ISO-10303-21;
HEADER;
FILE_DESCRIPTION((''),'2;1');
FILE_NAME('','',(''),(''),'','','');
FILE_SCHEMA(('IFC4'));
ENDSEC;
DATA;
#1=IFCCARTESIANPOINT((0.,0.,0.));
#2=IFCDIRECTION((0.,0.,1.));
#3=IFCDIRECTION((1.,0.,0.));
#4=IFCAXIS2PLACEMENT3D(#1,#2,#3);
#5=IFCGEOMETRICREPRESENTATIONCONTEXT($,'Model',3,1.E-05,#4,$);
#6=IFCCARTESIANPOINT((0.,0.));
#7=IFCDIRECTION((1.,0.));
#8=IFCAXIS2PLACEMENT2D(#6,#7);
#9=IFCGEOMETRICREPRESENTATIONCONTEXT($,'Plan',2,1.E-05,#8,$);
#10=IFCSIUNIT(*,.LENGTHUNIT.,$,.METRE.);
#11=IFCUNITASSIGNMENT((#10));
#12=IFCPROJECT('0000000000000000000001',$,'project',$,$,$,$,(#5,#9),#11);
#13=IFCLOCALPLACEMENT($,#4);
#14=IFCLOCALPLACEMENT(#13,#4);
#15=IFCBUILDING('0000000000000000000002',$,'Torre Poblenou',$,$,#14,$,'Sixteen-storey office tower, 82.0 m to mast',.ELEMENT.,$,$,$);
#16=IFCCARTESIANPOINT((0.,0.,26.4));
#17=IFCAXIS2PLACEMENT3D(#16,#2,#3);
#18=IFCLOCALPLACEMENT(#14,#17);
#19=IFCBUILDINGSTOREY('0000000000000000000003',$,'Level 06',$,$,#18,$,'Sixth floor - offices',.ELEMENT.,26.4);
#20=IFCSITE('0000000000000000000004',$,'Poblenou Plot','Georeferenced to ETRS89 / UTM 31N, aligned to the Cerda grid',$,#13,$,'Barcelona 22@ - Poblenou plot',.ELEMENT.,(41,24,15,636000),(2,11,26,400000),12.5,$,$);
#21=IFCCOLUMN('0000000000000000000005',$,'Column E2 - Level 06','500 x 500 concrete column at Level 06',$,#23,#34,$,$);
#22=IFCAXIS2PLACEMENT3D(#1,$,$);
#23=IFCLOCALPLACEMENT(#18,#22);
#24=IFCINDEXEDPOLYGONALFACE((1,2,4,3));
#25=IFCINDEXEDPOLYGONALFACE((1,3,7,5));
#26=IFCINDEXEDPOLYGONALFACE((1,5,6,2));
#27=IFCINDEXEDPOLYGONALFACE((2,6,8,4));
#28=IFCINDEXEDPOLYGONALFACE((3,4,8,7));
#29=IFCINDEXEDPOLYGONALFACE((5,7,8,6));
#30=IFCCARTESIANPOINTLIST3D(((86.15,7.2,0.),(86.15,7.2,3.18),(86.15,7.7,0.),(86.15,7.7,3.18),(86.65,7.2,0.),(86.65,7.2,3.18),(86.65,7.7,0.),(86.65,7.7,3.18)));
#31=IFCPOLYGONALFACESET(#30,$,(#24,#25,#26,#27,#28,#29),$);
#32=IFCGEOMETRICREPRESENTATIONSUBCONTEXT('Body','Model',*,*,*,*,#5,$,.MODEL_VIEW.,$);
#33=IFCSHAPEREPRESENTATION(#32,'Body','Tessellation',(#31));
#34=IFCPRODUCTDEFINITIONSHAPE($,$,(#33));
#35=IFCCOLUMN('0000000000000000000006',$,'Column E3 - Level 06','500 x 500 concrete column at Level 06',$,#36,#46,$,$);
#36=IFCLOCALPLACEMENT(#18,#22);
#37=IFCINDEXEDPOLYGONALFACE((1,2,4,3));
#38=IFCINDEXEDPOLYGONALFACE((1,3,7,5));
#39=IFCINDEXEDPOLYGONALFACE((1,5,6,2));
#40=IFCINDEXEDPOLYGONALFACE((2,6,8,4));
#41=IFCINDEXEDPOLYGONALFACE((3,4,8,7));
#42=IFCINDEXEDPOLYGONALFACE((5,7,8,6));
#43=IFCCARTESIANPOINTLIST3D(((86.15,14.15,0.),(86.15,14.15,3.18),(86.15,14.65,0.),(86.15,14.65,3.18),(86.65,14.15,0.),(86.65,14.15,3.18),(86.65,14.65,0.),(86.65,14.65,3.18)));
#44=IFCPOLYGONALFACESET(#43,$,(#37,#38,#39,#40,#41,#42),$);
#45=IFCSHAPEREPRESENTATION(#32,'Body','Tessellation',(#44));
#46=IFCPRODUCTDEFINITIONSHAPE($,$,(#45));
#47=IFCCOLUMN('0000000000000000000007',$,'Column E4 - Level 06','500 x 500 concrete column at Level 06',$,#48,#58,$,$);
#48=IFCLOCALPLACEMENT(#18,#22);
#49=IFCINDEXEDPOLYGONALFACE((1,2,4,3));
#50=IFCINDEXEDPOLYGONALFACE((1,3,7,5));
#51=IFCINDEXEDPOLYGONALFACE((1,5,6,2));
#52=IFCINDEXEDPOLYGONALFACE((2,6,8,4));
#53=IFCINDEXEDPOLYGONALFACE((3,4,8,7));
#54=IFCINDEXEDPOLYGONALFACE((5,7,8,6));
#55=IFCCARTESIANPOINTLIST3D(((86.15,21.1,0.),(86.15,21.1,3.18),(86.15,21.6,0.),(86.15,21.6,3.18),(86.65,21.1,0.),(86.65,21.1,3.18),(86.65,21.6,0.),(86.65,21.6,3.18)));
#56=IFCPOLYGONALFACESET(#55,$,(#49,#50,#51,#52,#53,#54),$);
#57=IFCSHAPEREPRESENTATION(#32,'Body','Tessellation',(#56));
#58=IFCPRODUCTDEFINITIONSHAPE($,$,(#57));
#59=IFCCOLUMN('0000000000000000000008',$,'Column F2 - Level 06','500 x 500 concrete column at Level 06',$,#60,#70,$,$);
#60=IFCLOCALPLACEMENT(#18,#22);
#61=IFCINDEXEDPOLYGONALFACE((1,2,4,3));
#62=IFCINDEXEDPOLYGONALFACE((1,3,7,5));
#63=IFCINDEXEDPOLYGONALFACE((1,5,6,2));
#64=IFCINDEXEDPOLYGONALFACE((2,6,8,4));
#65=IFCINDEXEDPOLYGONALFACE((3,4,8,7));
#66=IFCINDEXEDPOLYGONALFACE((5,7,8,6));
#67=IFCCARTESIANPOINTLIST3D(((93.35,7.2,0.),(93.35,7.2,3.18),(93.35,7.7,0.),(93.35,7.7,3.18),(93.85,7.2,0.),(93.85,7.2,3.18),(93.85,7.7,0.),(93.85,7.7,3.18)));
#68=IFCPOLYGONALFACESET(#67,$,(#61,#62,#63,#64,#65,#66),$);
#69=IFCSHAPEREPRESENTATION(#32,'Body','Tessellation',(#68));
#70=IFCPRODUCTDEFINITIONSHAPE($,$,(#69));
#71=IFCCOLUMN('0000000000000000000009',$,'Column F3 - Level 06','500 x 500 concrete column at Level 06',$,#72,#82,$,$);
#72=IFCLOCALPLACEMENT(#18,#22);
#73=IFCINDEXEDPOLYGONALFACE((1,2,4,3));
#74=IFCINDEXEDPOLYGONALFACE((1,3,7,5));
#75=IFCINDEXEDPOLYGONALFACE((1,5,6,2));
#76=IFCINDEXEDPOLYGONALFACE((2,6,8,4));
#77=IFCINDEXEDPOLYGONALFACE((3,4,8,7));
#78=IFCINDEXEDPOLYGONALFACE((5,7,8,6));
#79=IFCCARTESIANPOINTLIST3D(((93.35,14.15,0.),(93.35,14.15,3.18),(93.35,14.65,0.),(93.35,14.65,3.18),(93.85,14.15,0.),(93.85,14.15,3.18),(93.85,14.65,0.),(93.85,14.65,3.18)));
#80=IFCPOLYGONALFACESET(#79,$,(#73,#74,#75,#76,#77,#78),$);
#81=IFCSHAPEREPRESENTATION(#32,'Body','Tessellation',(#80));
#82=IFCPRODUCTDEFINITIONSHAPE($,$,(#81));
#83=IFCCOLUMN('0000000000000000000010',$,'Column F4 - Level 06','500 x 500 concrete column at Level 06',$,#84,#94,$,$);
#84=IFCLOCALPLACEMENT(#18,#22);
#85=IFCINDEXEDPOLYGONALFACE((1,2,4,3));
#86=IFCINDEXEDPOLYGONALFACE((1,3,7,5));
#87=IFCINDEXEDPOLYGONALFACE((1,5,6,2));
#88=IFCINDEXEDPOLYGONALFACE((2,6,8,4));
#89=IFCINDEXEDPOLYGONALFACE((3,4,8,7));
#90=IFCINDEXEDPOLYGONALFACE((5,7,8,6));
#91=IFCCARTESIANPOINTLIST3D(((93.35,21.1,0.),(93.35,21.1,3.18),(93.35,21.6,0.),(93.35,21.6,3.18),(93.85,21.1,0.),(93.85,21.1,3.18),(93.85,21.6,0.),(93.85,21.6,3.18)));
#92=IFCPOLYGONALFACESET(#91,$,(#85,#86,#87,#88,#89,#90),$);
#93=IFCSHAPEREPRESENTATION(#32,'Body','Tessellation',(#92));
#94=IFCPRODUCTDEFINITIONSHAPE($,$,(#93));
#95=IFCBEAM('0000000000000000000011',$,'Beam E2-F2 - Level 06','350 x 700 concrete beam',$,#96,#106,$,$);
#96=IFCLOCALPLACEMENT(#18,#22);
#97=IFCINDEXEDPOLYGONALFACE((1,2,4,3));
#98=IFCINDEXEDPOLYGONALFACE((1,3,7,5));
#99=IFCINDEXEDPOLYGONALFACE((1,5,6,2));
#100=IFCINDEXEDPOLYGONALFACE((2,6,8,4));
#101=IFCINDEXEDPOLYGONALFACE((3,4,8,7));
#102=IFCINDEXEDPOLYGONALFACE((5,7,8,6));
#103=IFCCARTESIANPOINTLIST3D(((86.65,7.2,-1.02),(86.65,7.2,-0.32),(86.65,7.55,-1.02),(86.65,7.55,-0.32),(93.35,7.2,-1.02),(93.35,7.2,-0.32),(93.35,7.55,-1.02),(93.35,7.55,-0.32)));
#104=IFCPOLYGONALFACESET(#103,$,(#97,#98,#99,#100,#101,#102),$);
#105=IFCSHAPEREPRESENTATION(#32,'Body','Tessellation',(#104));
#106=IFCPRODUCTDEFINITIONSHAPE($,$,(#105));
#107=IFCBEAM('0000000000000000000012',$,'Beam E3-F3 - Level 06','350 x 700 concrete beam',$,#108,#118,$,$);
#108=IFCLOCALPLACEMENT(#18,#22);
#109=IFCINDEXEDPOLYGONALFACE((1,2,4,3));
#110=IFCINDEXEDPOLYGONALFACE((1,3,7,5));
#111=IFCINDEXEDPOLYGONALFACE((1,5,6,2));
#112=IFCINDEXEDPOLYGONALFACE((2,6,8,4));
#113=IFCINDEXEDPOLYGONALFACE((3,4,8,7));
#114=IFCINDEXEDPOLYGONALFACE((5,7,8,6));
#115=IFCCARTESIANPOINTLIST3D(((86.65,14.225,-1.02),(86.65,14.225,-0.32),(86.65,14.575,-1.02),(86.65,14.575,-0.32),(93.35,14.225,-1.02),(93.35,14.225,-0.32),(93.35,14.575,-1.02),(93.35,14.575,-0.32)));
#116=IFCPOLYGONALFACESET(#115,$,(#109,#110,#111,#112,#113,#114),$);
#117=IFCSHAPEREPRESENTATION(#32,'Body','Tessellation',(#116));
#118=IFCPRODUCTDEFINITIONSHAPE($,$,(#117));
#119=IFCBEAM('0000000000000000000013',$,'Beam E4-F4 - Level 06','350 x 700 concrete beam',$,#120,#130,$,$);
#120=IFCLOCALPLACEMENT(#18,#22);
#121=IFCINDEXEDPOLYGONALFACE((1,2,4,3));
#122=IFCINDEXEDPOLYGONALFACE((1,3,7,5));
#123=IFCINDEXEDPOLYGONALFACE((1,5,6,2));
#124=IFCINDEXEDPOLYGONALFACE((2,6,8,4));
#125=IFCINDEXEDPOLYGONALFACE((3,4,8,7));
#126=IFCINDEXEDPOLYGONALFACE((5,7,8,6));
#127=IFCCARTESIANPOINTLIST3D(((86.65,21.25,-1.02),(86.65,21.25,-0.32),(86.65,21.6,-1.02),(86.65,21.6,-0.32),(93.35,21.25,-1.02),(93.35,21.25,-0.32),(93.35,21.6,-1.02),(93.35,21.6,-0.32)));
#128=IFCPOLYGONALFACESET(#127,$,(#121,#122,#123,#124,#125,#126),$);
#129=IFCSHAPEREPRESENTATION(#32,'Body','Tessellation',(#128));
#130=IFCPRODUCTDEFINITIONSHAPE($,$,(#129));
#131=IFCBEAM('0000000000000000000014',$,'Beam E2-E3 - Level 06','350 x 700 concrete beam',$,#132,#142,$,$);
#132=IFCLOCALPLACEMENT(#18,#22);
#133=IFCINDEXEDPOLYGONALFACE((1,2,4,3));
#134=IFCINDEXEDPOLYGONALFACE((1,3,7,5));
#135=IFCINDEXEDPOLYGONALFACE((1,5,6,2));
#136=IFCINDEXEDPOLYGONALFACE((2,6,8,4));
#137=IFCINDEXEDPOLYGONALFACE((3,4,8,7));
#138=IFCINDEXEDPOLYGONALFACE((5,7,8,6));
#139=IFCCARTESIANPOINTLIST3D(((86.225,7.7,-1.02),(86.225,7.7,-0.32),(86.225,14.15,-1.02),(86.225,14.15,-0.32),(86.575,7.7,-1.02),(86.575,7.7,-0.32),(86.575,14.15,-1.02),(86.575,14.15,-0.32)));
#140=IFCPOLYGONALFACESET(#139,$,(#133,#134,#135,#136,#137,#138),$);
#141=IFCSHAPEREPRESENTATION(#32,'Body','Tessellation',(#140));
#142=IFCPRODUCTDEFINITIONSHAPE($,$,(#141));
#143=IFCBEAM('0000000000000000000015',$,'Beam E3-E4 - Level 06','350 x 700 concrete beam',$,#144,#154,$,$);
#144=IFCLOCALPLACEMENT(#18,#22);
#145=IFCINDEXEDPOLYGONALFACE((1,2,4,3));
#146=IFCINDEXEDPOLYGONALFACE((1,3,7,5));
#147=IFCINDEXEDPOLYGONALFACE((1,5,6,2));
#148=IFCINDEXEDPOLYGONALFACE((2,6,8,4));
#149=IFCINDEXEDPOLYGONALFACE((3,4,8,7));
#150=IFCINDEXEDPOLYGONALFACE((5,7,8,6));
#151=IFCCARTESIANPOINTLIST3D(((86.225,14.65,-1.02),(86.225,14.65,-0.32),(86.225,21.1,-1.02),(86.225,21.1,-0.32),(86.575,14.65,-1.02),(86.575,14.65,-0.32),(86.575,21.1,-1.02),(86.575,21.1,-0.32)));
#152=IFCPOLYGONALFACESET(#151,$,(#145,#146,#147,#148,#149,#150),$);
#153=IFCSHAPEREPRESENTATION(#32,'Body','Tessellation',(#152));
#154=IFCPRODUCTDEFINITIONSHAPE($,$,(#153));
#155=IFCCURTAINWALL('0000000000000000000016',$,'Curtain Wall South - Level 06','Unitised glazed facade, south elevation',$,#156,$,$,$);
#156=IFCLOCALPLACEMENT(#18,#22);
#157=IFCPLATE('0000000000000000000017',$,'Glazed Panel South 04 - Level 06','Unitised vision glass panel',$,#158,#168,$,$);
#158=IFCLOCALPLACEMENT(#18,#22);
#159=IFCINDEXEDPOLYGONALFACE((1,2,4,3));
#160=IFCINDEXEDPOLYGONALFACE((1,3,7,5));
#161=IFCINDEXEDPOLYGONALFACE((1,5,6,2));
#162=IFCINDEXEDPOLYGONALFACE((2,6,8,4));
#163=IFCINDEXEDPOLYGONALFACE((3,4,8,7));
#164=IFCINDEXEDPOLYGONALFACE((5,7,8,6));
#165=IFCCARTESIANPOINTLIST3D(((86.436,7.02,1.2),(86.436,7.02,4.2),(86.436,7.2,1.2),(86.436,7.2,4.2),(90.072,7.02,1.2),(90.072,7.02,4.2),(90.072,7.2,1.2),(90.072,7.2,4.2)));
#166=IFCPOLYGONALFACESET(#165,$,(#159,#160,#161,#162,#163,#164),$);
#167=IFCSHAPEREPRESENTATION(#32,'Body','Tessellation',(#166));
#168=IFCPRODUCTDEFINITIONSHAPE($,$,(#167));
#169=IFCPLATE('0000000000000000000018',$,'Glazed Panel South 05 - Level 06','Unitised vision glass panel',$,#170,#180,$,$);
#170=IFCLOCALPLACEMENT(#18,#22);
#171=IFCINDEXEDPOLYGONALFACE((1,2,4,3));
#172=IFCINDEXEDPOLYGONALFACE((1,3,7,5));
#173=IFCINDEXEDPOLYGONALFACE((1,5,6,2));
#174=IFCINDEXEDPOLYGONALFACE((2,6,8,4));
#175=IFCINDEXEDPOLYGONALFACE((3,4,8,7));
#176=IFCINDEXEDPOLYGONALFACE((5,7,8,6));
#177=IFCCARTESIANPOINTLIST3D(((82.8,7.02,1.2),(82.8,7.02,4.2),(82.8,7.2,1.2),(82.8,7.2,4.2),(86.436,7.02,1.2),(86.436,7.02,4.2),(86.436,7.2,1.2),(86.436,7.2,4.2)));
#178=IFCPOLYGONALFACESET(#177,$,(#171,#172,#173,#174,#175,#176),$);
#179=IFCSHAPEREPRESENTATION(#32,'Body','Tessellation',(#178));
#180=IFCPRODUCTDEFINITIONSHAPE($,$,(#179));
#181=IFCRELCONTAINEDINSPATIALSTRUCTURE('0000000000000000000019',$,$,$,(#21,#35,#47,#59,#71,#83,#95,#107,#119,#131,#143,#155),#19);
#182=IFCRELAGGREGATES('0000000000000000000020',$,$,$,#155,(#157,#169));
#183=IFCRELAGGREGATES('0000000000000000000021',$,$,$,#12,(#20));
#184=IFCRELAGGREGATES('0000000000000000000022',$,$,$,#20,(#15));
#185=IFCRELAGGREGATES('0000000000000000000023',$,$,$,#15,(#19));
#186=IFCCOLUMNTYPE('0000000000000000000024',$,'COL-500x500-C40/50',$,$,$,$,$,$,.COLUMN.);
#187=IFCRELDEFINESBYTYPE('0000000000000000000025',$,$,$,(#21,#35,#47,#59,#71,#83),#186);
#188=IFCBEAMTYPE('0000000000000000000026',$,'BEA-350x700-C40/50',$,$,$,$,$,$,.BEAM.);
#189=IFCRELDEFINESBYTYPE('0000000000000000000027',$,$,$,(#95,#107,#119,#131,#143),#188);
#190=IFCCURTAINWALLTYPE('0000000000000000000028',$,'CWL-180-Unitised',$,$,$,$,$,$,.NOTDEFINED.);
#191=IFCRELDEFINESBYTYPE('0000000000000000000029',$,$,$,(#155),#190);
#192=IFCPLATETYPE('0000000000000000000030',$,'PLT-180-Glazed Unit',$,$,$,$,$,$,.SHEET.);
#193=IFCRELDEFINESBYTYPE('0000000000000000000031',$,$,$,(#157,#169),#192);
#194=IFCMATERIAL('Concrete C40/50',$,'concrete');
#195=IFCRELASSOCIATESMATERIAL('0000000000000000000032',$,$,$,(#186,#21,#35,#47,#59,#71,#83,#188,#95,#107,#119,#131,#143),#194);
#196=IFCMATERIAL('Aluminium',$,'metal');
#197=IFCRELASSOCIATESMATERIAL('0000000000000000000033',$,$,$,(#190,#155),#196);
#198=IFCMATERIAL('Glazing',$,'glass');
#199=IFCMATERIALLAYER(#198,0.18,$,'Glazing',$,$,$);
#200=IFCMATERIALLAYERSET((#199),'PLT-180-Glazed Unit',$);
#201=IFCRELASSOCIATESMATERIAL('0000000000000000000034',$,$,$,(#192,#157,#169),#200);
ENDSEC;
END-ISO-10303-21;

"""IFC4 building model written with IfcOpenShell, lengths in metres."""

from ifc_helpers import new_model, si_unit, frame, origin_with_axes, origin_2d_with_axis, place, context, subcontext, project, spatial, line, indexed_curve, rectangle, outline, extrude, material, layer, layer_set, layer_usage, material_profile, profile_set, profile_usage, type_object, element, aggregate, save


model = new_model("IFC4")

# Units and contexts
model_context = context("Model", 3, precision=1e-05, world=origin_with_axes())
plan_context = context("Plan", 2, precision=1e-05, world=origin_2d_with_axis())
body_context = subcontext(model_context, "Body", "Model", "MODEL_VIEW")
ifc_project = project(units=[si_unit("LENGTHUNIT", "METRE")], contexts=[model_context, plan_context])

# Site, building, storey
site_placement = place(None, origin_with_axes())
site = spatial("IfcSite", under=ifc_project, at=site_placement, Name="Poblenou Plot", Description="Georeferenced to ETRS89 / UTM 31N, aligned to the Cerda grid", LongName="Barcelona 22@ - Poblenou plot", CompositionType="ELEMENT", RefLatitude=(41, 24, 15, 636000), RefLongitude=(2, 11, 26, 400000), RefElevation=12.5)
building_placement = place(site_placement, origin_with_axes())
building = spatial("IfcBuilding", under=site, at=building_placement, Name="Torre Poblenou", LongName="Sixteen-storey office tower, 82.0 m to mast", CompositionType="ELEMENT")
storey_placement = place(building_placement, frame((0.0, 0.0, 26.4), z_axis=(0.0, 0.0, 1.0), x_axis=(1.0, 0.0, 0.0)))
storey = spatial("IfcBuildingStorey", under=building, at=storey_placement, Name="Level 06", LongName="Sixth floor - offices", CompositionType="ELEMENT", Elevation=26.4)

# Columns
ifc_material_1 = material(Name="Concrete C40/50", Category="concrete")
ifc_material_profile_1 = material_profile(ifc_material_1, rectangle(XDim=0.5, YDim=0.5))
ifc_profile_set_1 = profile_set([ifc_material_profile_1], Name="COL-500x500-C40/50")
ifc_profile_usage_1 = profile_usage(ifc_profile_set_1)
column_type = type_object("IfcColumnType", Name="COL-500x500-C40/50", PredefinedType="COLUMN", material=ifc_profile_set_1)
column_1_placement = place(storey_placement, frame((86.15, 7.2, 0.0), z_axis=(0.0, 0.0, 1.0), x_axis=(1.0, 0.0, 0.0)))
element("IfcColumn", 1, at=column_1_placement, inside=storey, type_object=column_type, material=ifc_profile_usage_1, Name="Column E2 - Level 06", Description="500 x 500 concrete column at Level 06", context=body_context, shape_type="SweptSolid", body=[
    extrude(outline(indexed_curve([(0.0, 0.0), (0.5, 0.0), (0.5, 0.5), (0.0, 0.5)], segments=[line(1, 2, 3, 4, 1)])), origin_with_axes(), (0.0, 0.0, 1.0), 3.18),
])
ifc_profile_usage_2 = profile_usage(ifc_profile_set_1)
column_2_placement = place(storey_placement, frame((86.15, 14.15, 0.0), z_axis=(0.0, 0.0, 1.0), x_axis=(1.0, 0.0, 0.0)))
element("IfcColumn", 2, at=column_2_placement, inside=storey, type_object=column_type, material=ifc_profile_usage_2, Name="Column E3 - Level 06", Description="500 x 500 concrete column at Level 06", context=body_context, shape_type="SweptSolid", body=[
    extrude(outline(indexed_curve([(0.0, 0.0), (0.5, 0.0), (0.5, 0.5), (0.0, 0.5)], segments=[line(1, 2, 3, 4, 1)])), origin_with_axes(), (0.0, 0.0, 1.0), 3.18),
])
ifc_profile_usage_3 = profile_usage(ifc_profile_set_1)
column_3_placement = place(storey_placement, frame((86.15, 21.1, 0.0), z_axis=(0.0, 0.0, 1.0), x_axis=(1.0, 0.0, 0.0)))
element("IfcColumn", 3, at=column_3_placement, inside=storey, type_object=column_type, material=ifc_profile_usage_3, Name="Column E4 - Level 06", Description="500 x 500 concrete column at Level 06", context=body_context, shape_type="SweptSolid", body=[
    extrude(outline(indexed_curve([(0.0, 0.0), (0.5, 0.0), (0.5, 0.5), (0.0, 0.5)], segments=[line(1, 2, 3, 4, 1)])), origin_with_axes(), (0.0, 0.0, 1.0), 3.18),
])
ifc_profile_usage_4 = profile_usage(ifc_profile_set_1)
column_4_placement = place(storey_placement, frame((93.35, 7.2, 0.0), z_axis=(0.0, 0.0, 1.0), x_axis=(1.0, 0.0, 0.0)))
element("IfcColumn", 4, at=column_4_placement, inside=storey, type_object=column_type, material=ifc_profile_usage_4, Name="Column F2 - Level 06", Description="500 x 500 concrete column at Level 06", context=body_context, shape_type="SweptSolid", body=[
    extrude(outline(indexed_curve([(0.0, 0.0), (0.5, 0.0), (0.5, 0.5), (0.0, 0.5)], segments=[line(1, 2, 3, 4, 1)])), origin_with_axes(), (0.0, 0.0, 1.0), 3.18),
])
ifc_profile_usage_5 = profile_usage(ifc_profile_set_1)
column_5_placement = place(storey_placement, frame((93.35, 14.15, 0.0), z_axis=(0.0, 0.0, 1.0), x_axis=(1.0, 0.0, 0.0)))
element("IfcColumn", 5, at=column_5_placement, inside=storey, type_object=column_type, material=ifc_profile_usage_5, Name="Column F3 - Level 06", Description="500 x 500 concrete column at Level 06", context=body_context, shape_type="SweptSolid", body=[
    extrude(outline(indexed_curve([(0.0, 0.0), (0.5, 0.0), (0.5, 0.5), (0.0, 0.5)], segments=[line(1, 2, 3, 4, 1)])), origin_with_axes(), (0.0, 0.0, 1.0), 3.18),
])
ifc_profile_usage_6 = profile_usage(ifc_profile_set_1)
column_6_placement = place(storey_placement, frame((93.35, 21.1, 0.0), z_axis=(0.0, 0.0, 1.0), x_axis=(1.0, 0.0, 0.0)))
element("IfcColumn", 6, at=column_6_placement, inside=storey, type_object=column_type, material=ifc_profile_usage_6, Name="Column F4 - Level 06", Description="500 x 500 concrete column at Level 06", context=body_context, shape_type="SweptSolid", body=[
    extrude(outline(indexed_curve([(0.0, 0.0), (0.5, 0.0), (0.5, 0.5), (0.0, 0.5)], segments=[line(1, 2, 3, 4, 1)])), origin_with_axes(), (0.0, 0.0, 1.0), 3.18),
])

# Beams
ifc_material_profile_2 = material_profile(ifc_material_1, rectangle(XDim=0.35, YDim=0.7))
ifc_profile_set_2 = profile_set([ifc_material_profile_2], Name="BEA-350x700-C40/50")
ifc_profile_usage_7 = profile_usage(ifc_profile_set_2)
beam_type = type_object("IfcBeamType", Name="BEA-350x700-C40/50", PredefinedType="BEAM", material=ifc_profile_set_2)
beam_1_placement = place(storey_placement, frame((86.65, 7.2, -1.02), z_axis=(0.0, 0.0, 1.0), x_axis=(1.0, 0.0, 0.0)))
element("IfcBeam", 7, at=beam_1_placement, inside=storey, type_object=beam_type, material=ifc_profile_usage_7, Name="Beam E2-F2 - Level 06", Description="350 x 700 concrete beam", context=body_context, shape_type="SweptSolid", body=[
    extrude(outline(indexed_curve([(0.0, 0.0), (6.7, 0.0), (6.7, 0.35), (0.0, 0.35)], segments=[line(1, 2, 3, 4, 1)])), origin_with_axes(), (0.0, 0.0, 1.0), 0.7),
])
ifc_profile_usage_8 = profile_usage(ifc_profile_set_2)
beam_2_placement = place(storey_placement, frame((86.65, 14.225, -1.02), z_axis=(0.0, 0.0, 1.0), x_axis=(1.0, 0.0, 0.0)))
element("IfcBeam", 8, at=beam_2_placement, inside=storey, type_object=beam_type, material=ifc_profile_usage_8, Name="Beam E3-F3 - Level 06", Description="350 x 700 concrete beam", context=body_context, shape_type="SweptSolid", body=[
    extrude(outline(indexed_curve([(0.0, 0.0), (6.7, 0.0), (6.7, 0.35), (0.0, 0.35)], segments=[line(1, 2, 3, 4, 1)])), origin_with_axes(), (0.0, 0.0, 1.0), 0.7),
])
ifc_profile_usage_9 = profile_usage(ifc_profile_set_2)
beam_3_placement = place(storey_placement, frame((86.65, 21.25, -1.02), z_axis=(0.0, 0.0, 1.0), x_axis=(1.0, 0.0, 0.0)))
element("IfcBeam", 9, at=beam_3_placement, inside=storey, type_object=beam_type, material=ifc_profile_usage_9, Name="Beam E4-F4 - Level 06", Description="350 x 700 concrete beam", context=body_context, shape_type="SweptSolid", body=[
    extrude(outline(indexed_curve([(0.0, 0.0), (6.7, 0.0), (6.7, 0.35), (0.0, 0.35)], segments=[line(1, 2, 3, 4, 1)])), origin_with_axes(), (0.0, 0.0, 1.0), 0.7),
])
ifc_profile_usage_10 = profile_usage(ifc_profile_set_2)
beam_4_placement = place(storey_placement, frame((86.575, 7.7, -1.02), z_axis=(0.0, 0.0, 1.0), x_axis=(0.0, 1.0, 0.0)))
element("IfcBeam", 10, at=beam_4_placement, inside=storey, type_object=beam_type, material=ifc_profile_usage_10, Name="Beam E2-E3 - Level 06", Description="350 x 700 concrete beam", context=body_context, shape_type="SweptSolid", body=[
    extrude(outline(indexed_curve([(0.0, 0.0), (6.45, 0.0), (6.45, 0.35), (0.0, 0.35)], segments=[line(1, 2, 3, 4, 1)])), origin_with_axes(), (0.0, 0.0, 1.0), 0.7),
])
ifc_profile_usage_11 = profile_usage(ifc_profile_set_2)
beam_5_placement = place(storey_placement, frame((86.575, 14.65, -1.02), z_axis=(0.0, 0.0, 1.0), x_axis=(0.0, 1.0, 0.0)))
element("IfcBeam", 11, at=beam_5_placement, inside=storey, type_object=beam_type, material=ifc_profile_usage_11, Name="Beam E3-E4 - Level 06", Description="350 x 700 concrete beam", context=body_context, shape_type="SweptSolid", body=[
    extrude(outline(indexed_curve([(0.0, 0.0), (6.45, 0.0), (6.45, 0.35), (0.0, 0.35)], segments=[line(1, 2, 3, 4, 1)])), origin_with_axes(), (0.0, 0.0, 1.0), 0.7),
])

# Curtain wall, plates
ifc_material_2 = material(Name="Aluminium", Category="metal")
curtain_wall_type = type_object("IfcCurtainWallType", Name="CWL-180-Unitised", PredefinedType="NOTDEFINED", material=ifc_material_2)
curtain_wall_1_placement = place(storey_placement, frame((100.98, 7.2, 0.0), z_axis=(0.0, 0.0, 1.0), x_axis=(-1.0, 0.0, 0.0)))
curtain_wall_1 = element("IfcCurtainWall", 12, at=curtain_wall_1_placement, inside=storey, type_object=curtain_wall_type, material=ifc_material_2, Name="Curtain Wall South - Level 06", Description="Unitised glazed facade, south elevation")
ifc_material_3 = material(Name="Glazing", Category="glass")
ifc_layer_1 = layer(ifc_material_3, 0.18, Name="Glazing")
ifc_layer_set_1 = layer_set([ifc_layer_1], Name="PLT-180-Glazed Unit")
ifc_layer_usage_1 = layer_usage(ifc_layer_set_1, "AXIS2", "POSITIVE", 0.0)
plate_type_1 = type_object("IfcPlateType", Name="PLT-180-Glazed Unit", PredefinedType="SHEET", material=ifc_layer_set_1)
plate_1_placement = place(curtain_wall_1_placement, frame((10.908, 0.0, 1.2), z_axis=(0.0, 0.0, 1.0), x_axis=(1.0, 0.0, 0.0)))
plate_1 = element("IfcPlate", 13, at=plate_1_placement, type_object=plate_type_1, material=ifc_layer_usage_1, Name="Glazed Panel South 04 - Level 06", Description="Unitised vision glass panel", context=body_context, shape_type="SweptSolid", body=[
    extrude(outline(indexed_curve([(0.0, 0.0), (3.636, 0.0), (3.636, 0.18), (0.0, 0.18)], segments=[line(1, 2, 3, 4, 1)])), origin_with_axes(), (0.0, 0.0, 1.0), 3.0),
])
ifc_layer_usage_2 = layer_usage(ifc_layer_set_1, "AXIS2", "POSITIVE", 0.0)
plate_2_placement = place(curtain_wall_1_placement, frame((14.544, 0.0, 1.2), z_axis=(0.0, 0.0, 1.0), x_axis=(1.0, 0.0, 0.0)))
plate_2 = element("IfcPlate", 14, at=plate_2_placement, type_object=plate_type_1, material=ifc_layer_usage_2, Name="Glazed Panel South 05 - Level 06", Description="Unitised vision glass panel", context=body_context, shape_type="SweptSolid", body=[
    extrude(outline(indexed_curve([(0.0, 0.0), (3.636, 0.0), (3.636, 0.18), (0.0, 0.18)], segments=[line(1, 2, 3, 4, 1)])), origin_with_axes(), (0.0, 0.0, 1.0), 3.0),
])

aggregate(curtain_wall_1, [plate_1, plate_2])

save(model, "model.ifc")
